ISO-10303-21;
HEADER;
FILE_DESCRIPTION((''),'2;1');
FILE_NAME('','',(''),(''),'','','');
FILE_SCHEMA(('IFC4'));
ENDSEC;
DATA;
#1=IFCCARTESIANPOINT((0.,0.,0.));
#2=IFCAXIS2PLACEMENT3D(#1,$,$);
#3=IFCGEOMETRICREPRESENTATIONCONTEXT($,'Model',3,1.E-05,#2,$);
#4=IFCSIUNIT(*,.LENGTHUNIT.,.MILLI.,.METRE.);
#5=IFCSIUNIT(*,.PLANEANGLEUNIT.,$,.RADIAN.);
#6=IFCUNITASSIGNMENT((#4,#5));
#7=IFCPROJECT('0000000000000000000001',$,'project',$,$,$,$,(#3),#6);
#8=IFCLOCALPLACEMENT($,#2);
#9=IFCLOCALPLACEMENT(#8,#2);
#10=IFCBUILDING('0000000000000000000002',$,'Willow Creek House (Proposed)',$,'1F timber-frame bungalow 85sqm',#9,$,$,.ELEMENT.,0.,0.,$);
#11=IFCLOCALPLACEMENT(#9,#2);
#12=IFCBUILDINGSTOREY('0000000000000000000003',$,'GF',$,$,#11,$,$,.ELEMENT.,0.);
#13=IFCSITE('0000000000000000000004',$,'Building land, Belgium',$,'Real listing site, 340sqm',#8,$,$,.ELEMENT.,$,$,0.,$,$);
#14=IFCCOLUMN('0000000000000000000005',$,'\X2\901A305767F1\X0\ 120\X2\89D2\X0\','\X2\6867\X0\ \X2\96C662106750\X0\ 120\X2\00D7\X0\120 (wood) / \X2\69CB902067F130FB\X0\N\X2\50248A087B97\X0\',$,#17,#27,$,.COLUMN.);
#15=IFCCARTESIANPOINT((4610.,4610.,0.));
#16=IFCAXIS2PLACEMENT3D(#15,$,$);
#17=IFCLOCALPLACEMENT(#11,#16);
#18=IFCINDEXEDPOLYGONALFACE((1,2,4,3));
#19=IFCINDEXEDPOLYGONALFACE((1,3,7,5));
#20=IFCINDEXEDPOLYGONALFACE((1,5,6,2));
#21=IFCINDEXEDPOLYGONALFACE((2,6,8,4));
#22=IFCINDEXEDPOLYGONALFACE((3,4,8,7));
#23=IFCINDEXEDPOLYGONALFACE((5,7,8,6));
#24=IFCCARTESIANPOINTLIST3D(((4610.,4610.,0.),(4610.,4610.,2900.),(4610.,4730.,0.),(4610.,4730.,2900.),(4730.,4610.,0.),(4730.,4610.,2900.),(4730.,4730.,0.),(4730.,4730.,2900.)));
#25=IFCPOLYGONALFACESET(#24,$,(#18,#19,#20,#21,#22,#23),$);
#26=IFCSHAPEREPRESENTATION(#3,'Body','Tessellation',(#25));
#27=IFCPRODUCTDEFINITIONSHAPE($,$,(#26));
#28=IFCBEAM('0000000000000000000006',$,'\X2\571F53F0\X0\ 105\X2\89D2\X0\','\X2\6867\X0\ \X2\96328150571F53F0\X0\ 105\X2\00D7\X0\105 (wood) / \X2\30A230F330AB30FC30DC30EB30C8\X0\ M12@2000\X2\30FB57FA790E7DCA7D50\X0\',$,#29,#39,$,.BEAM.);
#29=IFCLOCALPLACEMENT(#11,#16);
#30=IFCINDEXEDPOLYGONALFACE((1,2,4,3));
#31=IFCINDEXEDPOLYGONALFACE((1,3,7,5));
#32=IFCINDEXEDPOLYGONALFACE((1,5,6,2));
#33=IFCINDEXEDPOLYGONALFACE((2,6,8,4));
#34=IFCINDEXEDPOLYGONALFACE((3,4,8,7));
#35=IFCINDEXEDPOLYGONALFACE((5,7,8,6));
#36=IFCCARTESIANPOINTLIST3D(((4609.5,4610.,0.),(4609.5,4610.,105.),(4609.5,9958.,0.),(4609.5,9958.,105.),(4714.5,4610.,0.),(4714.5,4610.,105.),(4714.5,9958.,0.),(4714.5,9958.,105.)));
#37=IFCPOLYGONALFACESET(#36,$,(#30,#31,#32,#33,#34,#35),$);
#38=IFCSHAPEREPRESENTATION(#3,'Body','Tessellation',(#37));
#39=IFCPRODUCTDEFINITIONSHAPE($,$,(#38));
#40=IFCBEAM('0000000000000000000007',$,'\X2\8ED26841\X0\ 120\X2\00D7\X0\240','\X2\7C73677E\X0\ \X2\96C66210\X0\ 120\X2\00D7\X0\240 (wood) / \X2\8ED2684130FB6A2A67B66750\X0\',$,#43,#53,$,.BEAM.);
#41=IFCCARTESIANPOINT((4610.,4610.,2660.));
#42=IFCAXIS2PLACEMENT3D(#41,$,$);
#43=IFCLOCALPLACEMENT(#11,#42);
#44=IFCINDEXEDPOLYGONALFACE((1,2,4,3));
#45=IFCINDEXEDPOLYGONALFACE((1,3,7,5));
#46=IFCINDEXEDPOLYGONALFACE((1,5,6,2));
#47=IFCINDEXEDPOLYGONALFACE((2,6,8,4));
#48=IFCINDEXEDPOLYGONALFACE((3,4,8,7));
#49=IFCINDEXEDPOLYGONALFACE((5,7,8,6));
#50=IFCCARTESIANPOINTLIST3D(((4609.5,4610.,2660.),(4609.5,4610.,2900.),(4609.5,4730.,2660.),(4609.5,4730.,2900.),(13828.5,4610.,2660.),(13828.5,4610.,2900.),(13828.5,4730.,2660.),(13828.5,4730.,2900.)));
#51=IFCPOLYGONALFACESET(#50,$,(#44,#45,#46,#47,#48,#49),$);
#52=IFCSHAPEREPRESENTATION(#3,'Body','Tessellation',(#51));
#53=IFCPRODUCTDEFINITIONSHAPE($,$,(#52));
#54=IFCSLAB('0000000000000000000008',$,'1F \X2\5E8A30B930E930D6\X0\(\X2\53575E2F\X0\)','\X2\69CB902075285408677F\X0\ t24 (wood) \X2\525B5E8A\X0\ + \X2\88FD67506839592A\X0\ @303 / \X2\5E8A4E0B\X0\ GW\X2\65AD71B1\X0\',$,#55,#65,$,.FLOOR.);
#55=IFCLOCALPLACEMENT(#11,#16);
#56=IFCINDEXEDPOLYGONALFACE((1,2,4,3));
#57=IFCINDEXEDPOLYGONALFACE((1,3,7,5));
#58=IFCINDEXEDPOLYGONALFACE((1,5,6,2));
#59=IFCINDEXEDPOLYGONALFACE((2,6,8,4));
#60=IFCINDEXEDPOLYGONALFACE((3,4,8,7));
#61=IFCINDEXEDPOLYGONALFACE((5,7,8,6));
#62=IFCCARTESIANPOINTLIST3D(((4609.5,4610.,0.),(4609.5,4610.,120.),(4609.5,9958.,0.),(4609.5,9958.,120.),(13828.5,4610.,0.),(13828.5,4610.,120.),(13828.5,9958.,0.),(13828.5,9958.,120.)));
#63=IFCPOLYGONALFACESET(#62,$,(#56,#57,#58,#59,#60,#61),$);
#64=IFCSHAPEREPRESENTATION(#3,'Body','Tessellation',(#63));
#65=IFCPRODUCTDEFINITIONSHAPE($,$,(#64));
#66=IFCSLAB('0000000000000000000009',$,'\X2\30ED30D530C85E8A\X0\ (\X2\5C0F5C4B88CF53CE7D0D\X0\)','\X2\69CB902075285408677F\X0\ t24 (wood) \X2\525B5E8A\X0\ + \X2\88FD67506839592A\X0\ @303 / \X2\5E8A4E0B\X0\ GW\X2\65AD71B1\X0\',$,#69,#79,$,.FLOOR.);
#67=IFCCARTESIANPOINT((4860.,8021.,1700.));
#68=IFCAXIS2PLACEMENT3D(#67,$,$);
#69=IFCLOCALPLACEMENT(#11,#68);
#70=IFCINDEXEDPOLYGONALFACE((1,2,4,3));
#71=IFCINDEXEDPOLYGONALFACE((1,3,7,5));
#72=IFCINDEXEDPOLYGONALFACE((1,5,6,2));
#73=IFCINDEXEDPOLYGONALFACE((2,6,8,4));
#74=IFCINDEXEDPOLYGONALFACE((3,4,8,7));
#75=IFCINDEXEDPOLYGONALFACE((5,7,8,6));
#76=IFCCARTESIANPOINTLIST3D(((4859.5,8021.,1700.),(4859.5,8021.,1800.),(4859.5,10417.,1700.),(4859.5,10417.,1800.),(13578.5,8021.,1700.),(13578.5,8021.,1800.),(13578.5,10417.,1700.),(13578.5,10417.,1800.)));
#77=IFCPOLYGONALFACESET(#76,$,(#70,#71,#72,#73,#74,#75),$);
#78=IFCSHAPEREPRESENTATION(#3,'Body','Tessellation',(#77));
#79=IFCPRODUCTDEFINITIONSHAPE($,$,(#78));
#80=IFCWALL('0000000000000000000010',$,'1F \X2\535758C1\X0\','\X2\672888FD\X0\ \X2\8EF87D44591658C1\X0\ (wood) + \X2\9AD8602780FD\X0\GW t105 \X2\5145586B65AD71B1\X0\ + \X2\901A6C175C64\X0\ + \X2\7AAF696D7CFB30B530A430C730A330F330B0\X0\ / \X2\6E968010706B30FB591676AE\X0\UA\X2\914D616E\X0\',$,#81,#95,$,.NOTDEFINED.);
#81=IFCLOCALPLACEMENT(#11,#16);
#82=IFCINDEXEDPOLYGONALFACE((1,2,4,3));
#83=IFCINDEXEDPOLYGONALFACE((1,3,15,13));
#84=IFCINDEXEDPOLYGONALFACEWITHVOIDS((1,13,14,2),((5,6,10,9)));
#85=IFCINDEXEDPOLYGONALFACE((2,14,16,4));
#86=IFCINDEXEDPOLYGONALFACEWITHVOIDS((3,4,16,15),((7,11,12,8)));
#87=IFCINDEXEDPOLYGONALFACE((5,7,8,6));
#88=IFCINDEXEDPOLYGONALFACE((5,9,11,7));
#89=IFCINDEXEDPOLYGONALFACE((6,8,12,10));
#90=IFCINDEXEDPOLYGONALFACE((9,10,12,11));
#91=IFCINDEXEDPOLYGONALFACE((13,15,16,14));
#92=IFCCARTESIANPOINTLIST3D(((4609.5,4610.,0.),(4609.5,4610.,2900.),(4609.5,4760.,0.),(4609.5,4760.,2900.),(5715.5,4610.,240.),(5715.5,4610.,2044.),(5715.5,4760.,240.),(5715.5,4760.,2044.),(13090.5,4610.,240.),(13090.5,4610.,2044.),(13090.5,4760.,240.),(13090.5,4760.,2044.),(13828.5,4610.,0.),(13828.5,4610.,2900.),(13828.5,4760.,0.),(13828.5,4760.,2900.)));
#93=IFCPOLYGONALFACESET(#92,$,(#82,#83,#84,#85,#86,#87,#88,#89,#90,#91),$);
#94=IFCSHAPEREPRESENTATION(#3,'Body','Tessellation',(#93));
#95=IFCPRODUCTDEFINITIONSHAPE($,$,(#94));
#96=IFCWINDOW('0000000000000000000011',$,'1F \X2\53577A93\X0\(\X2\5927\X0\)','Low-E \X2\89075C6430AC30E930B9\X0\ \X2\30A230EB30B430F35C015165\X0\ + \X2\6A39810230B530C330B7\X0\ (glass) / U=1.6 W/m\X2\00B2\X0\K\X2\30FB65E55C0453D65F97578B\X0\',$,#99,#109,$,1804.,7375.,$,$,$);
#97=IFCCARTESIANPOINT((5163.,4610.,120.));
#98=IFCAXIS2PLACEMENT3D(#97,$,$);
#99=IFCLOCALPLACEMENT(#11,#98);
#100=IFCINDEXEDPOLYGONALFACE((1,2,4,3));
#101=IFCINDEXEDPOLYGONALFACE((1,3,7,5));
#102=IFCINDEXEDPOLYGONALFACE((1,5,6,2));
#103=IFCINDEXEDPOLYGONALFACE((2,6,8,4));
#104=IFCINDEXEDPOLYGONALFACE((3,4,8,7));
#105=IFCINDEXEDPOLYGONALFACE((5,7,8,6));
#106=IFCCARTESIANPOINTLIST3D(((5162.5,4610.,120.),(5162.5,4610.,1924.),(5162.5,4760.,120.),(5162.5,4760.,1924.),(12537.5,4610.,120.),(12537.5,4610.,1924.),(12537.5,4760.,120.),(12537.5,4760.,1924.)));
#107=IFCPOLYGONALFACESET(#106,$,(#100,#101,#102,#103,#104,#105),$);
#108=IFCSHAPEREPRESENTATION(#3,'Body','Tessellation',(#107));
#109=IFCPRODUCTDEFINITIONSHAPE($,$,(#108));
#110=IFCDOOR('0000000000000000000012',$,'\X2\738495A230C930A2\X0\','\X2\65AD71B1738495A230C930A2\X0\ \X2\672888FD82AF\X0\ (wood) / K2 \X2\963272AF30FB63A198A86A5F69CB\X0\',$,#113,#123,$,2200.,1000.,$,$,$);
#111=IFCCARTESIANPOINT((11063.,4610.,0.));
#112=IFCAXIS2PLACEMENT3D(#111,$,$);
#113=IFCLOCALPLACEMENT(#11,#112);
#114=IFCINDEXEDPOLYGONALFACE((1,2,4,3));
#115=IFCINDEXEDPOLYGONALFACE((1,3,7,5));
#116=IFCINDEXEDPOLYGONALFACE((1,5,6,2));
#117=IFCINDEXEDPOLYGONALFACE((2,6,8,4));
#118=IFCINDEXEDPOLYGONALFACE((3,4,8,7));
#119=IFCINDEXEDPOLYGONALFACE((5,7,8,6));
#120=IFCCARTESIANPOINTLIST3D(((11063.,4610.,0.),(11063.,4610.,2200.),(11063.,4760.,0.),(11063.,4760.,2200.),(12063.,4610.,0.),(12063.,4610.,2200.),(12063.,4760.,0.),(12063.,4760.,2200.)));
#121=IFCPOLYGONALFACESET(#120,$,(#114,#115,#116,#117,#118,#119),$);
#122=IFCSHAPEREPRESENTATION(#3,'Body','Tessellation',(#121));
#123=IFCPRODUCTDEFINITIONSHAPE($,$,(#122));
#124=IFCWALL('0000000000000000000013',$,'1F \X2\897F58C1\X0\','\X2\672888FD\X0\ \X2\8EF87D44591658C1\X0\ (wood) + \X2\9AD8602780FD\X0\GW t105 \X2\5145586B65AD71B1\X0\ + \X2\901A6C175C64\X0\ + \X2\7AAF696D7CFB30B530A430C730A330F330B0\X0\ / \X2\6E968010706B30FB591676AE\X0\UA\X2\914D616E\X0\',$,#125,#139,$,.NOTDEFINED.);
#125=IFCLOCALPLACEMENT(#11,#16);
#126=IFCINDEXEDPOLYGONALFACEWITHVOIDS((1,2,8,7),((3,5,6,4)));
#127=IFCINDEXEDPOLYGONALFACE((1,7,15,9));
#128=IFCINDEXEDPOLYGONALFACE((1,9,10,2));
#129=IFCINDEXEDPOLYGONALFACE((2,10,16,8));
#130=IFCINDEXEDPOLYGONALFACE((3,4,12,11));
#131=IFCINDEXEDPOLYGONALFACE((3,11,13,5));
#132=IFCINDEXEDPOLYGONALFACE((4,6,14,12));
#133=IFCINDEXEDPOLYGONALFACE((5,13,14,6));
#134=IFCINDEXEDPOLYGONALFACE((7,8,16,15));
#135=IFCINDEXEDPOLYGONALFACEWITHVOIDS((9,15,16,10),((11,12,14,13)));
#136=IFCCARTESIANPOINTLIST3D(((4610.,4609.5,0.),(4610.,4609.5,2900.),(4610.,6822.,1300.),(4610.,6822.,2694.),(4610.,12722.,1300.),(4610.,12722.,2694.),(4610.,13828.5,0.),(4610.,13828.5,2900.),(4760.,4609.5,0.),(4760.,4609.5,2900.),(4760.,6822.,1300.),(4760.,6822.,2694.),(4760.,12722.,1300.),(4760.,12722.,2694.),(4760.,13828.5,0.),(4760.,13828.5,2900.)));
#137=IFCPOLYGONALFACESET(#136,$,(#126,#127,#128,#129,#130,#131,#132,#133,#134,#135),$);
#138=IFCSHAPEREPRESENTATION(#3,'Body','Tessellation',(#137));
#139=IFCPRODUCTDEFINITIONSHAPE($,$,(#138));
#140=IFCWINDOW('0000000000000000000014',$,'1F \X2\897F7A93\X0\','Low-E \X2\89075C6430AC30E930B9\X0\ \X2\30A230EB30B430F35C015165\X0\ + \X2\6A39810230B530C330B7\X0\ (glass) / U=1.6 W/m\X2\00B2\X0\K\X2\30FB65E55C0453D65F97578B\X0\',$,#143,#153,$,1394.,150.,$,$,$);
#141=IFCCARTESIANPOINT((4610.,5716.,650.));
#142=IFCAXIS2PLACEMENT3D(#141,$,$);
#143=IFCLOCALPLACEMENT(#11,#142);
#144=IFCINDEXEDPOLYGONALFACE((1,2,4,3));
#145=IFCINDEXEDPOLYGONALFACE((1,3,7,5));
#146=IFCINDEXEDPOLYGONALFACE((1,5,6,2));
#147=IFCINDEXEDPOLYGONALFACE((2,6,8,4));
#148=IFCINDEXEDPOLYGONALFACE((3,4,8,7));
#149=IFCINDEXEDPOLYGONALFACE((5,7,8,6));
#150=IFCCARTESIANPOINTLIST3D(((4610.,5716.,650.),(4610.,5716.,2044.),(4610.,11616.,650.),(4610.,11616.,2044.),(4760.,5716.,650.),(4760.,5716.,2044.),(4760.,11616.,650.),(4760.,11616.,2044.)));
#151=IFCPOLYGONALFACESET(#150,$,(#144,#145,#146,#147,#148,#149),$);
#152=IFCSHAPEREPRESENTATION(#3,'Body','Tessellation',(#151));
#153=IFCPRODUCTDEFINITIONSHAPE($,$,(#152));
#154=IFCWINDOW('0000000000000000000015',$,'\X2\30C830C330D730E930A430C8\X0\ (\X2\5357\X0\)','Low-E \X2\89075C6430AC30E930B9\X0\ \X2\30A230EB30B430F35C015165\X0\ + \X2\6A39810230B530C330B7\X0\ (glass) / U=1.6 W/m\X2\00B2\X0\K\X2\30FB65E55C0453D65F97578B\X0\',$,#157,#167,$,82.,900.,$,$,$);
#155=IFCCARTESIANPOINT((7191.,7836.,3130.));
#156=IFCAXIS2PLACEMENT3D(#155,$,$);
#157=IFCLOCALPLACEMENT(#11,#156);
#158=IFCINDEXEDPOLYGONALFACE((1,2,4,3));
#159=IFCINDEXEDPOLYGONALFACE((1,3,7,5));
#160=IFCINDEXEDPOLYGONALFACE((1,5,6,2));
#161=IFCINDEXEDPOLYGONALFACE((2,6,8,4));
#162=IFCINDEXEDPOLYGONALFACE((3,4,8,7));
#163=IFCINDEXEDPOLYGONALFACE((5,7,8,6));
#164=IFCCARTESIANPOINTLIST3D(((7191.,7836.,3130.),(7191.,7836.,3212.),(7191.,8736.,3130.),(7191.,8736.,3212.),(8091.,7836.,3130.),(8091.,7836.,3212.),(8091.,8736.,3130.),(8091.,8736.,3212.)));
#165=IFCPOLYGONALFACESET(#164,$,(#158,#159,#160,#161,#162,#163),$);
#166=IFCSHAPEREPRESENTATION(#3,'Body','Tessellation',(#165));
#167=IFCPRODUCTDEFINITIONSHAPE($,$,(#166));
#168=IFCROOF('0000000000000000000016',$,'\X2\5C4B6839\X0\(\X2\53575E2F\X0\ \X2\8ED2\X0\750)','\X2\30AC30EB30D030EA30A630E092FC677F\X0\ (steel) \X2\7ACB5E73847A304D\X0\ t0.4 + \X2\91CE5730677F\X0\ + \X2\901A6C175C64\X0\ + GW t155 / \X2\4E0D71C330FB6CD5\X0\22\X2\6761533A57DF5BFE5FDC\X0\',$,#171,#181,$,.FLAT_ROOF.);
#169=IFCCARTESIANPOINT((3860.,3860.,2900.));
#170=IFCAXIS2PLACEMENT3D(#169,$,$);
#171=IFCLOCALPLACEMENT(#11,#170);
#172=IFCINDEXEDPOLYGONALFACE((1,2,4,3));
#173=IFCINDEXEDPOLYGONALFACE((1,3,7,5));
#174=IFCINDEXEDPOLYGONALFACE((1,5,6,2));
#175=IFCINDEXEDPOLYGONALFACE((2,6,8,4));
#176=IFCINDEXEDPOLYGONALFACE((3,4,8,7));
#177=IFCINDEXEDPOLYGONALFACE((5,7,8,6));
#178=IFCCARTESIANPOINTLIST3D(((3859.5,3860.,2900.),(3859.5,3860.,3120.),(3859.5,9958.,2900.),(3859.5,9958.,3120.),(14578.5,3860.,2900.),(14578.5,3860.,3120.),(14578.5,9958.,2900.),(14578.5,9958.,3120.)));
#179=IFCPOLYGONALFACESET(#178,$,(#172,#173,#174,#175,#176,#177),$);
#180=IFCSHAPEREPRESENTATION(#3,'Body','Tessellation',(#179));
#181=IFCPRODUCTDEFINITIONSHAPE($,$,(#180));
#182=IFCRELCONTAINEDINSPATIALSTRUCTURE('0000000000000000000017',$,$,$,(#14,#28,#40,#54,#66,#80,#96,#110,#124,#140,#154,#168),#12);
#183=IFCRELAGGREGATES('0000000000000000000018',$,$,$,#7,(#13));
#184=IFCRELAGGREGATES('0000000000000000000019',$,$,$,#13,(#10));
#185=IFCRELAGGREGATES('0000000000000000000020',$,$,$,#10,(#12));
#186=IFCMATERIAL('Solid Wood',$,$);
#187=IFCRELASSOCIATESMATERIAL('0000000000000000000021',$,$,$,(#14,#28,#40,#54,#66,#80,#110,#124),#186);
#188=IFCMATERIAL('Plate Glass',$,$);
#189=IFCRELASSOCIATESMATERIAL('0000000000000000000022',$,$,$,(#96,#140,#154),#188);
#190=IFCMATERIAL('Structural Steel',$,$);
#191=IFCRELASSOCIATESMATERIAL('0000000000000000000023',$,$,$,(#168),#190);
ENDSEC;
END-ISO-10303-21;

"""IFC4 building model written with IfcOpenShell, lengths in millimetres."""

from ifc_helpers import new_model, si_unit, frame, frame_2d, origin, place, context, project, spatial, rectangle, extrude, material, element, fill, save


model = new_model("IFC4")

# Units and contexts
model_context = context("Model", 3, precision=1e-05, world=origin())
ifc_project = project(units=[si_unit("LENGTHUNIT", "METRE", prefix="MILLI"), si_unit("PLANEANGLEUNIT", "RADIAN")], contexts=[model_context])

# Site, building, storey
site_placement = place(None, origin())
site = spatial("IfcSite", under=ifc_project, at=site_placement, Name="Building land, Belgium", ObjectType="Real listing site, 340sqm", CompositionType="ELEMENT", RefElevation=0.0)
building_placement = place(site_placement, origin())
building = spatial("IfcBuilding", under=site, at=building_placement, Name="Willow Creek House (Proposed)", ObjectType="1F timber-frame bungalow 85sqm", CompositionType="ELEMENT", ElevationOfRefHeight=0.0, ElevationOfTerrain=0.0)
storey_placement = place(building_placement, origin())
storey = spatial("IfcBuildingStorey", under=building, at=storey_placement, Name="GF", CompositionType="ELEMENT", Elevation=0.0)

# Column
ifc_material_1 = material(Name="Solid Wood")
column_1_placement = place(storey_placement, frame((4610.0, 4610.0, 0.0)))
element("IfcColumn", 1, at=column_1_placement, inside=storey, material=ifc_material_1, Name="通し柱 120角", Description="桧 集成材 120×120 (wood) / 構造柱・N値計算", PredefinedType="COLUMN", context=model_context, shape_type="SweptSolid", body=[
    extrude(rectangle(XDim=120.0, YDim=120.0, at=frame_2d((60.0, 60.0))), frame((4610.0, 4610.0, 0.0)), (0.0, 0.0, 1.0), 2900.0),
])

# Beams
beam_1_placement = place(storey_placement, frame((4610.0, 4610.0, 0.0)))
element("IfcBeam", 2, at=beam_1_placement, inside=storey, material=ifc_material_1, Name="土台 105角", Description="桧 防腐土台 105×105 (wood) / アンカーボルト M12@2000・基礎緊結", PredefinedType="BEAM", context=model_context, shape_type="SweptSolid", body=[
    extrude(rectangle(XDim=105.0, YDim=5348.0, at=frame_2d((52.0, 2674.0))), frame((4610.0, 4610.0, 0.0)), (0.0, 0.0, 1.0), 105.0),
])
beam_2_placement = place(storey_placement, frame((4610.0, 4610.0, 2660.0)))
element("IfcBeam", 3, at=beam_2_placement, inside=storey, material=ifc_material_1, Name="軒桁 120×240", Description="米松 集成 120×240 (wood) / 軒桁・横架材", PredefinedType="BEAM", context=model_context, shape_type="SweptSolid", body=[
    extrude(rectangle(XDim=9219.0, YDim=120.0, at=frame_2d((4609.0, 60.0))), frame((4610.0, 4610.0, 2660.0)), (0.0, 0.0, 1.0), 240.0),
])

# Slabs
slab_1_placement = place(storey_placement, frame((4610.0, 4610.0, 0.0)))
element("IfcSlab", 4, at=slab_1_placement, inside=storey, material=ifc_material_1, Name="1F 床スラブ(南帯)", Description="構造用合板 t24 (wood) 剛床 + 製材根太 @303 / 床下 GW断熱", PredefinedType="FLOOR", context=model_context, shape_type="SweptSolid", body=[
    extrude(rectangle(XDim=9219.0, YDim=5348.0, at=frame_2d((4609.0, 2674.0))), frame((4610.0, 4610.0, 0.0)), (0.0, 0.0, 1.0), 120.0),
])
slab_2_placement = place(storey_placement, frame((4860.0, 8021.0, 1700.0)))
element("IfcSlab", 5, at=slab_2_placement, inside=storey, material=ifc_material_1, Name="ロフト床 (小屋裏収納)", Description="構造用合板 t24 (wood) 剛床 + 製材根太 @303 / 床下 GW断熱", PredefinedType="FLOOR", context=model_context, shape_type="SweptSolid", body=[
    extrude(rectangle(XDim=8719.0, YDim=2396.0, at=frame_2d((4359.0, 1198.0))), frame((4860.0, 8021.0, 1700.0)), (0.0, 0.0, 1.0), 100.0),
])

# Wall, openings, window, door
wall_1_placement = place(storey_placement, frame((4610.0, 4610.0, 0.0)))
wall_1 = element("IfcWall", 6, at=wall_1_placement, inside=storey, material=ifc_material_1, Name="1F 南壁", Description="木製 軸組外壁 (wood) + 高性能GW t105 充填断熱 + 通気層 + 窯業系サイディング / 準耐火・外皮UA配慮", PredefinedType="NOTDEFINED", context=model_context, shape_type="SweptSolid", body=[
    extrude(rectangle(XDim=9219.0, YDim=150.0, at=frame_2d((4609.0, 75.0))), frame((4610.0, 4610.0, 0.0)), (0.0, 0.0, 1.0), 2900.0),
])
opening_1_placement = place(storey_placement, frame((5163.0, 4610.0, 120.0)))
opening_1 = element("IfcOpeningElement", 7, at=opening_1_placement, cuts=wall_1, PredefinedType="NOTDEFINED", context=model_context, shape_type="SweptSolid", body=[
    extrude(rectangle(XDim=7375.0, YDim=150.0, at=frame_2d((3687.0, 75.0))), frame((5163.0, 4610.0, 120.0)), (0.0, 0.0, 1.0), 1804.0),
])
opening_2_placement = place(storey_placement, frame((11063.0, 4610.0, 0.0)))
opening_2 = element("IfcOpeningElement", 8, at=opening_2_placement, cuts=wall_1, PredefinedType="NOTDEFINED", context=model_context, shape_type="SweptSolid", body=[
    extrude(rectangle(XDim=1000.0, YDim=150.0, at=frame_2d((500.0, 75.0))), frame((11063.0, 4610.0, 0.0)), (0.0, 0.0, 1.0), 2200.0),
])
ifc_material_2 = material(Name="Plate Glass")
window_1_placement = place(storey_placement, frame((5163.0, 4610.0, 120.0)))
window_1 = element("IfcWindow", 9, at=window_1_placement, inside=storey, material=ifc_material_2, Name="1F 南窓(大)", Description="Low-E 複層ガラス アルゴン封入 + 樹脂サッシ (glass) / U=1.6 W/m²K・日射取得型", OverallHeight=1804.0, OverallWidth=7375.0, context=model_context, shape_type="SweptSolid", body=[
    extrude(rectangle(XDim=7375.0, YDim=150.0, at=frame_2d((3687.0, 75.0))), frame((5163.0, 4610.0, 120.0)), (0.0, 0.0, 1.0), 1804.0),
])
fill(opening_1, window_1)
door_1_placement = place(storey_placement, frame((11063.0, 4610.0, 0.0)))
door_1 = element("IfcDoor", 10, at=door_1_placement, inside=storey, material=ifc_material_1, Name="玄関ドア", Description="断熱玄関ドア 木製芯 (wood) / K2 防犯・採風機構", OverallHeight=2200.0, OverallWidth=1000.0, context=model_context, shape_type="SweptSolid", body=[
    extrude(rectangle(XDim=1000.0, YDim=150.0, at=frame_2d((500.0, 75.0))), frame((11063.0, 4610.0, 0.0)), (0.0, 0.0, 1.0), 2200.0),
])
fill(opening_2, door_1)

# Wall, opening, window
wall_2_placement = place(storey_placement, frame((4610.0, 4610.0, 0.0)))
wall_2 = element("IfcWall", 11, at=wall_2_placement, inside=storey, material=ifc_material_1, Name="1F 西壁", Description="木製 軸組外壁 (wood) + 高性能GW t105 充填断熱 + 通気層 + 窯業系サイディング / 準耐火・外皮UA配慮", PredefinedType="NOTDEFINED", context=model_context, shape_type="SweptSolid", body=[
    extrude(rectangle(XDim=150.0, YDim=9219.0, at=frame_2d((75.0, 4609.0))), frame((4610.0, 4610.0, 0.0)), (0.0, 0.0, 1.0), 2900.0),
])
opening_3_placement = place(storey_placement, frame((4610.0, 5716.0, 650.0)))
opening_3 = element("IfcOpeningElement", 12, at=opening_3_placement, cuts=wall_2, PredefinedType="NOTDEFINED", context=model_context, shape_type="SweptSolid", body=[
    extrude(rectangle(XDim=150.0, YDim=5900.0, at=frame_2d((75.0, 2950.0))), frame((4610.0, 5716.0, 650.0)), (0.0, 0.0, 1.0), 1394.0),
])
window_2_placement = place(storey_placement, frame((4610.0, 5716.0, 650.0)))
window_2 = element("IfcWindow", 13, at=window_2_placement, inside=storey, material=ifc_material_2, Name="1F 西窓", Description="Low-E 複層ガラス アルゴン封入 + 樹脂サッシ (glass) / U=1.6 W/m²K・日射取得型", OverallHeight=1394.0, OverallWidth=150.0, context=model_context, shape_type="SweptSolid", body=[
    extrude(rectangle(XDim=150.0, YDim=5900.0, at=frame_2d((75.0, 2950.0))), frame((4610.0, 5716.0, 650.0)), (0.0, 0.0, 1.0), 1394.0),
])
fill(opening_3, window_2)

# Window
window_3_placement = place(storey_placement, frame((7191.0, 7836.0, 3130.0)))
element("IfcWindow", 14, at=window_3_placement, inside=storey, material=ifc_material_2, Name="トップライト (南)", Description="Low-E 複層ガラス アルゴン封入 + 樹脂サッシ (glass) / U=1.6 W/m²K・日射取得型", OverallHeight=82.0, OverallWidth=900.0, context=model_context, shape_type="SweptSolid", body=[
    extrude(rectangle(XDim=900.0, YDim=900.0, at=frame_2d((450.0, 450.0))), frame((7191.0, 7836.0, 3130.0)), (0.0, 0.0, 1.0), 82.0),
])

# Roof
ifc_material_3 = material(Name="Structural Steel")
roof_placement = place(storey_placement, frame((3860.0, 3860.0, 2900.0)))
element("IfcRoof", 15, at=roof_placement, inside=storey, material=ifc_material_3, Name="屋根(南帯 軒750)", Description="ガルバリウム鋼板 (steel) 立平葺き t0.4 + 野地板 + 通気層 + GW t155 / 不燃・法22条区域対応", PredefinedType="FLAT_ROOF", context=model_context, shape_type="SweptSolid", body=[
    extrude(rectangle(XDim=10719.0, YDim=6098.0, at=frame_2d((5359.0, 3049.0))), frame((3860.0, 3860.0, 2900.0)), (0.0, 0.0, 1.0), 220.0),
])

save(model, "model.ifc")
